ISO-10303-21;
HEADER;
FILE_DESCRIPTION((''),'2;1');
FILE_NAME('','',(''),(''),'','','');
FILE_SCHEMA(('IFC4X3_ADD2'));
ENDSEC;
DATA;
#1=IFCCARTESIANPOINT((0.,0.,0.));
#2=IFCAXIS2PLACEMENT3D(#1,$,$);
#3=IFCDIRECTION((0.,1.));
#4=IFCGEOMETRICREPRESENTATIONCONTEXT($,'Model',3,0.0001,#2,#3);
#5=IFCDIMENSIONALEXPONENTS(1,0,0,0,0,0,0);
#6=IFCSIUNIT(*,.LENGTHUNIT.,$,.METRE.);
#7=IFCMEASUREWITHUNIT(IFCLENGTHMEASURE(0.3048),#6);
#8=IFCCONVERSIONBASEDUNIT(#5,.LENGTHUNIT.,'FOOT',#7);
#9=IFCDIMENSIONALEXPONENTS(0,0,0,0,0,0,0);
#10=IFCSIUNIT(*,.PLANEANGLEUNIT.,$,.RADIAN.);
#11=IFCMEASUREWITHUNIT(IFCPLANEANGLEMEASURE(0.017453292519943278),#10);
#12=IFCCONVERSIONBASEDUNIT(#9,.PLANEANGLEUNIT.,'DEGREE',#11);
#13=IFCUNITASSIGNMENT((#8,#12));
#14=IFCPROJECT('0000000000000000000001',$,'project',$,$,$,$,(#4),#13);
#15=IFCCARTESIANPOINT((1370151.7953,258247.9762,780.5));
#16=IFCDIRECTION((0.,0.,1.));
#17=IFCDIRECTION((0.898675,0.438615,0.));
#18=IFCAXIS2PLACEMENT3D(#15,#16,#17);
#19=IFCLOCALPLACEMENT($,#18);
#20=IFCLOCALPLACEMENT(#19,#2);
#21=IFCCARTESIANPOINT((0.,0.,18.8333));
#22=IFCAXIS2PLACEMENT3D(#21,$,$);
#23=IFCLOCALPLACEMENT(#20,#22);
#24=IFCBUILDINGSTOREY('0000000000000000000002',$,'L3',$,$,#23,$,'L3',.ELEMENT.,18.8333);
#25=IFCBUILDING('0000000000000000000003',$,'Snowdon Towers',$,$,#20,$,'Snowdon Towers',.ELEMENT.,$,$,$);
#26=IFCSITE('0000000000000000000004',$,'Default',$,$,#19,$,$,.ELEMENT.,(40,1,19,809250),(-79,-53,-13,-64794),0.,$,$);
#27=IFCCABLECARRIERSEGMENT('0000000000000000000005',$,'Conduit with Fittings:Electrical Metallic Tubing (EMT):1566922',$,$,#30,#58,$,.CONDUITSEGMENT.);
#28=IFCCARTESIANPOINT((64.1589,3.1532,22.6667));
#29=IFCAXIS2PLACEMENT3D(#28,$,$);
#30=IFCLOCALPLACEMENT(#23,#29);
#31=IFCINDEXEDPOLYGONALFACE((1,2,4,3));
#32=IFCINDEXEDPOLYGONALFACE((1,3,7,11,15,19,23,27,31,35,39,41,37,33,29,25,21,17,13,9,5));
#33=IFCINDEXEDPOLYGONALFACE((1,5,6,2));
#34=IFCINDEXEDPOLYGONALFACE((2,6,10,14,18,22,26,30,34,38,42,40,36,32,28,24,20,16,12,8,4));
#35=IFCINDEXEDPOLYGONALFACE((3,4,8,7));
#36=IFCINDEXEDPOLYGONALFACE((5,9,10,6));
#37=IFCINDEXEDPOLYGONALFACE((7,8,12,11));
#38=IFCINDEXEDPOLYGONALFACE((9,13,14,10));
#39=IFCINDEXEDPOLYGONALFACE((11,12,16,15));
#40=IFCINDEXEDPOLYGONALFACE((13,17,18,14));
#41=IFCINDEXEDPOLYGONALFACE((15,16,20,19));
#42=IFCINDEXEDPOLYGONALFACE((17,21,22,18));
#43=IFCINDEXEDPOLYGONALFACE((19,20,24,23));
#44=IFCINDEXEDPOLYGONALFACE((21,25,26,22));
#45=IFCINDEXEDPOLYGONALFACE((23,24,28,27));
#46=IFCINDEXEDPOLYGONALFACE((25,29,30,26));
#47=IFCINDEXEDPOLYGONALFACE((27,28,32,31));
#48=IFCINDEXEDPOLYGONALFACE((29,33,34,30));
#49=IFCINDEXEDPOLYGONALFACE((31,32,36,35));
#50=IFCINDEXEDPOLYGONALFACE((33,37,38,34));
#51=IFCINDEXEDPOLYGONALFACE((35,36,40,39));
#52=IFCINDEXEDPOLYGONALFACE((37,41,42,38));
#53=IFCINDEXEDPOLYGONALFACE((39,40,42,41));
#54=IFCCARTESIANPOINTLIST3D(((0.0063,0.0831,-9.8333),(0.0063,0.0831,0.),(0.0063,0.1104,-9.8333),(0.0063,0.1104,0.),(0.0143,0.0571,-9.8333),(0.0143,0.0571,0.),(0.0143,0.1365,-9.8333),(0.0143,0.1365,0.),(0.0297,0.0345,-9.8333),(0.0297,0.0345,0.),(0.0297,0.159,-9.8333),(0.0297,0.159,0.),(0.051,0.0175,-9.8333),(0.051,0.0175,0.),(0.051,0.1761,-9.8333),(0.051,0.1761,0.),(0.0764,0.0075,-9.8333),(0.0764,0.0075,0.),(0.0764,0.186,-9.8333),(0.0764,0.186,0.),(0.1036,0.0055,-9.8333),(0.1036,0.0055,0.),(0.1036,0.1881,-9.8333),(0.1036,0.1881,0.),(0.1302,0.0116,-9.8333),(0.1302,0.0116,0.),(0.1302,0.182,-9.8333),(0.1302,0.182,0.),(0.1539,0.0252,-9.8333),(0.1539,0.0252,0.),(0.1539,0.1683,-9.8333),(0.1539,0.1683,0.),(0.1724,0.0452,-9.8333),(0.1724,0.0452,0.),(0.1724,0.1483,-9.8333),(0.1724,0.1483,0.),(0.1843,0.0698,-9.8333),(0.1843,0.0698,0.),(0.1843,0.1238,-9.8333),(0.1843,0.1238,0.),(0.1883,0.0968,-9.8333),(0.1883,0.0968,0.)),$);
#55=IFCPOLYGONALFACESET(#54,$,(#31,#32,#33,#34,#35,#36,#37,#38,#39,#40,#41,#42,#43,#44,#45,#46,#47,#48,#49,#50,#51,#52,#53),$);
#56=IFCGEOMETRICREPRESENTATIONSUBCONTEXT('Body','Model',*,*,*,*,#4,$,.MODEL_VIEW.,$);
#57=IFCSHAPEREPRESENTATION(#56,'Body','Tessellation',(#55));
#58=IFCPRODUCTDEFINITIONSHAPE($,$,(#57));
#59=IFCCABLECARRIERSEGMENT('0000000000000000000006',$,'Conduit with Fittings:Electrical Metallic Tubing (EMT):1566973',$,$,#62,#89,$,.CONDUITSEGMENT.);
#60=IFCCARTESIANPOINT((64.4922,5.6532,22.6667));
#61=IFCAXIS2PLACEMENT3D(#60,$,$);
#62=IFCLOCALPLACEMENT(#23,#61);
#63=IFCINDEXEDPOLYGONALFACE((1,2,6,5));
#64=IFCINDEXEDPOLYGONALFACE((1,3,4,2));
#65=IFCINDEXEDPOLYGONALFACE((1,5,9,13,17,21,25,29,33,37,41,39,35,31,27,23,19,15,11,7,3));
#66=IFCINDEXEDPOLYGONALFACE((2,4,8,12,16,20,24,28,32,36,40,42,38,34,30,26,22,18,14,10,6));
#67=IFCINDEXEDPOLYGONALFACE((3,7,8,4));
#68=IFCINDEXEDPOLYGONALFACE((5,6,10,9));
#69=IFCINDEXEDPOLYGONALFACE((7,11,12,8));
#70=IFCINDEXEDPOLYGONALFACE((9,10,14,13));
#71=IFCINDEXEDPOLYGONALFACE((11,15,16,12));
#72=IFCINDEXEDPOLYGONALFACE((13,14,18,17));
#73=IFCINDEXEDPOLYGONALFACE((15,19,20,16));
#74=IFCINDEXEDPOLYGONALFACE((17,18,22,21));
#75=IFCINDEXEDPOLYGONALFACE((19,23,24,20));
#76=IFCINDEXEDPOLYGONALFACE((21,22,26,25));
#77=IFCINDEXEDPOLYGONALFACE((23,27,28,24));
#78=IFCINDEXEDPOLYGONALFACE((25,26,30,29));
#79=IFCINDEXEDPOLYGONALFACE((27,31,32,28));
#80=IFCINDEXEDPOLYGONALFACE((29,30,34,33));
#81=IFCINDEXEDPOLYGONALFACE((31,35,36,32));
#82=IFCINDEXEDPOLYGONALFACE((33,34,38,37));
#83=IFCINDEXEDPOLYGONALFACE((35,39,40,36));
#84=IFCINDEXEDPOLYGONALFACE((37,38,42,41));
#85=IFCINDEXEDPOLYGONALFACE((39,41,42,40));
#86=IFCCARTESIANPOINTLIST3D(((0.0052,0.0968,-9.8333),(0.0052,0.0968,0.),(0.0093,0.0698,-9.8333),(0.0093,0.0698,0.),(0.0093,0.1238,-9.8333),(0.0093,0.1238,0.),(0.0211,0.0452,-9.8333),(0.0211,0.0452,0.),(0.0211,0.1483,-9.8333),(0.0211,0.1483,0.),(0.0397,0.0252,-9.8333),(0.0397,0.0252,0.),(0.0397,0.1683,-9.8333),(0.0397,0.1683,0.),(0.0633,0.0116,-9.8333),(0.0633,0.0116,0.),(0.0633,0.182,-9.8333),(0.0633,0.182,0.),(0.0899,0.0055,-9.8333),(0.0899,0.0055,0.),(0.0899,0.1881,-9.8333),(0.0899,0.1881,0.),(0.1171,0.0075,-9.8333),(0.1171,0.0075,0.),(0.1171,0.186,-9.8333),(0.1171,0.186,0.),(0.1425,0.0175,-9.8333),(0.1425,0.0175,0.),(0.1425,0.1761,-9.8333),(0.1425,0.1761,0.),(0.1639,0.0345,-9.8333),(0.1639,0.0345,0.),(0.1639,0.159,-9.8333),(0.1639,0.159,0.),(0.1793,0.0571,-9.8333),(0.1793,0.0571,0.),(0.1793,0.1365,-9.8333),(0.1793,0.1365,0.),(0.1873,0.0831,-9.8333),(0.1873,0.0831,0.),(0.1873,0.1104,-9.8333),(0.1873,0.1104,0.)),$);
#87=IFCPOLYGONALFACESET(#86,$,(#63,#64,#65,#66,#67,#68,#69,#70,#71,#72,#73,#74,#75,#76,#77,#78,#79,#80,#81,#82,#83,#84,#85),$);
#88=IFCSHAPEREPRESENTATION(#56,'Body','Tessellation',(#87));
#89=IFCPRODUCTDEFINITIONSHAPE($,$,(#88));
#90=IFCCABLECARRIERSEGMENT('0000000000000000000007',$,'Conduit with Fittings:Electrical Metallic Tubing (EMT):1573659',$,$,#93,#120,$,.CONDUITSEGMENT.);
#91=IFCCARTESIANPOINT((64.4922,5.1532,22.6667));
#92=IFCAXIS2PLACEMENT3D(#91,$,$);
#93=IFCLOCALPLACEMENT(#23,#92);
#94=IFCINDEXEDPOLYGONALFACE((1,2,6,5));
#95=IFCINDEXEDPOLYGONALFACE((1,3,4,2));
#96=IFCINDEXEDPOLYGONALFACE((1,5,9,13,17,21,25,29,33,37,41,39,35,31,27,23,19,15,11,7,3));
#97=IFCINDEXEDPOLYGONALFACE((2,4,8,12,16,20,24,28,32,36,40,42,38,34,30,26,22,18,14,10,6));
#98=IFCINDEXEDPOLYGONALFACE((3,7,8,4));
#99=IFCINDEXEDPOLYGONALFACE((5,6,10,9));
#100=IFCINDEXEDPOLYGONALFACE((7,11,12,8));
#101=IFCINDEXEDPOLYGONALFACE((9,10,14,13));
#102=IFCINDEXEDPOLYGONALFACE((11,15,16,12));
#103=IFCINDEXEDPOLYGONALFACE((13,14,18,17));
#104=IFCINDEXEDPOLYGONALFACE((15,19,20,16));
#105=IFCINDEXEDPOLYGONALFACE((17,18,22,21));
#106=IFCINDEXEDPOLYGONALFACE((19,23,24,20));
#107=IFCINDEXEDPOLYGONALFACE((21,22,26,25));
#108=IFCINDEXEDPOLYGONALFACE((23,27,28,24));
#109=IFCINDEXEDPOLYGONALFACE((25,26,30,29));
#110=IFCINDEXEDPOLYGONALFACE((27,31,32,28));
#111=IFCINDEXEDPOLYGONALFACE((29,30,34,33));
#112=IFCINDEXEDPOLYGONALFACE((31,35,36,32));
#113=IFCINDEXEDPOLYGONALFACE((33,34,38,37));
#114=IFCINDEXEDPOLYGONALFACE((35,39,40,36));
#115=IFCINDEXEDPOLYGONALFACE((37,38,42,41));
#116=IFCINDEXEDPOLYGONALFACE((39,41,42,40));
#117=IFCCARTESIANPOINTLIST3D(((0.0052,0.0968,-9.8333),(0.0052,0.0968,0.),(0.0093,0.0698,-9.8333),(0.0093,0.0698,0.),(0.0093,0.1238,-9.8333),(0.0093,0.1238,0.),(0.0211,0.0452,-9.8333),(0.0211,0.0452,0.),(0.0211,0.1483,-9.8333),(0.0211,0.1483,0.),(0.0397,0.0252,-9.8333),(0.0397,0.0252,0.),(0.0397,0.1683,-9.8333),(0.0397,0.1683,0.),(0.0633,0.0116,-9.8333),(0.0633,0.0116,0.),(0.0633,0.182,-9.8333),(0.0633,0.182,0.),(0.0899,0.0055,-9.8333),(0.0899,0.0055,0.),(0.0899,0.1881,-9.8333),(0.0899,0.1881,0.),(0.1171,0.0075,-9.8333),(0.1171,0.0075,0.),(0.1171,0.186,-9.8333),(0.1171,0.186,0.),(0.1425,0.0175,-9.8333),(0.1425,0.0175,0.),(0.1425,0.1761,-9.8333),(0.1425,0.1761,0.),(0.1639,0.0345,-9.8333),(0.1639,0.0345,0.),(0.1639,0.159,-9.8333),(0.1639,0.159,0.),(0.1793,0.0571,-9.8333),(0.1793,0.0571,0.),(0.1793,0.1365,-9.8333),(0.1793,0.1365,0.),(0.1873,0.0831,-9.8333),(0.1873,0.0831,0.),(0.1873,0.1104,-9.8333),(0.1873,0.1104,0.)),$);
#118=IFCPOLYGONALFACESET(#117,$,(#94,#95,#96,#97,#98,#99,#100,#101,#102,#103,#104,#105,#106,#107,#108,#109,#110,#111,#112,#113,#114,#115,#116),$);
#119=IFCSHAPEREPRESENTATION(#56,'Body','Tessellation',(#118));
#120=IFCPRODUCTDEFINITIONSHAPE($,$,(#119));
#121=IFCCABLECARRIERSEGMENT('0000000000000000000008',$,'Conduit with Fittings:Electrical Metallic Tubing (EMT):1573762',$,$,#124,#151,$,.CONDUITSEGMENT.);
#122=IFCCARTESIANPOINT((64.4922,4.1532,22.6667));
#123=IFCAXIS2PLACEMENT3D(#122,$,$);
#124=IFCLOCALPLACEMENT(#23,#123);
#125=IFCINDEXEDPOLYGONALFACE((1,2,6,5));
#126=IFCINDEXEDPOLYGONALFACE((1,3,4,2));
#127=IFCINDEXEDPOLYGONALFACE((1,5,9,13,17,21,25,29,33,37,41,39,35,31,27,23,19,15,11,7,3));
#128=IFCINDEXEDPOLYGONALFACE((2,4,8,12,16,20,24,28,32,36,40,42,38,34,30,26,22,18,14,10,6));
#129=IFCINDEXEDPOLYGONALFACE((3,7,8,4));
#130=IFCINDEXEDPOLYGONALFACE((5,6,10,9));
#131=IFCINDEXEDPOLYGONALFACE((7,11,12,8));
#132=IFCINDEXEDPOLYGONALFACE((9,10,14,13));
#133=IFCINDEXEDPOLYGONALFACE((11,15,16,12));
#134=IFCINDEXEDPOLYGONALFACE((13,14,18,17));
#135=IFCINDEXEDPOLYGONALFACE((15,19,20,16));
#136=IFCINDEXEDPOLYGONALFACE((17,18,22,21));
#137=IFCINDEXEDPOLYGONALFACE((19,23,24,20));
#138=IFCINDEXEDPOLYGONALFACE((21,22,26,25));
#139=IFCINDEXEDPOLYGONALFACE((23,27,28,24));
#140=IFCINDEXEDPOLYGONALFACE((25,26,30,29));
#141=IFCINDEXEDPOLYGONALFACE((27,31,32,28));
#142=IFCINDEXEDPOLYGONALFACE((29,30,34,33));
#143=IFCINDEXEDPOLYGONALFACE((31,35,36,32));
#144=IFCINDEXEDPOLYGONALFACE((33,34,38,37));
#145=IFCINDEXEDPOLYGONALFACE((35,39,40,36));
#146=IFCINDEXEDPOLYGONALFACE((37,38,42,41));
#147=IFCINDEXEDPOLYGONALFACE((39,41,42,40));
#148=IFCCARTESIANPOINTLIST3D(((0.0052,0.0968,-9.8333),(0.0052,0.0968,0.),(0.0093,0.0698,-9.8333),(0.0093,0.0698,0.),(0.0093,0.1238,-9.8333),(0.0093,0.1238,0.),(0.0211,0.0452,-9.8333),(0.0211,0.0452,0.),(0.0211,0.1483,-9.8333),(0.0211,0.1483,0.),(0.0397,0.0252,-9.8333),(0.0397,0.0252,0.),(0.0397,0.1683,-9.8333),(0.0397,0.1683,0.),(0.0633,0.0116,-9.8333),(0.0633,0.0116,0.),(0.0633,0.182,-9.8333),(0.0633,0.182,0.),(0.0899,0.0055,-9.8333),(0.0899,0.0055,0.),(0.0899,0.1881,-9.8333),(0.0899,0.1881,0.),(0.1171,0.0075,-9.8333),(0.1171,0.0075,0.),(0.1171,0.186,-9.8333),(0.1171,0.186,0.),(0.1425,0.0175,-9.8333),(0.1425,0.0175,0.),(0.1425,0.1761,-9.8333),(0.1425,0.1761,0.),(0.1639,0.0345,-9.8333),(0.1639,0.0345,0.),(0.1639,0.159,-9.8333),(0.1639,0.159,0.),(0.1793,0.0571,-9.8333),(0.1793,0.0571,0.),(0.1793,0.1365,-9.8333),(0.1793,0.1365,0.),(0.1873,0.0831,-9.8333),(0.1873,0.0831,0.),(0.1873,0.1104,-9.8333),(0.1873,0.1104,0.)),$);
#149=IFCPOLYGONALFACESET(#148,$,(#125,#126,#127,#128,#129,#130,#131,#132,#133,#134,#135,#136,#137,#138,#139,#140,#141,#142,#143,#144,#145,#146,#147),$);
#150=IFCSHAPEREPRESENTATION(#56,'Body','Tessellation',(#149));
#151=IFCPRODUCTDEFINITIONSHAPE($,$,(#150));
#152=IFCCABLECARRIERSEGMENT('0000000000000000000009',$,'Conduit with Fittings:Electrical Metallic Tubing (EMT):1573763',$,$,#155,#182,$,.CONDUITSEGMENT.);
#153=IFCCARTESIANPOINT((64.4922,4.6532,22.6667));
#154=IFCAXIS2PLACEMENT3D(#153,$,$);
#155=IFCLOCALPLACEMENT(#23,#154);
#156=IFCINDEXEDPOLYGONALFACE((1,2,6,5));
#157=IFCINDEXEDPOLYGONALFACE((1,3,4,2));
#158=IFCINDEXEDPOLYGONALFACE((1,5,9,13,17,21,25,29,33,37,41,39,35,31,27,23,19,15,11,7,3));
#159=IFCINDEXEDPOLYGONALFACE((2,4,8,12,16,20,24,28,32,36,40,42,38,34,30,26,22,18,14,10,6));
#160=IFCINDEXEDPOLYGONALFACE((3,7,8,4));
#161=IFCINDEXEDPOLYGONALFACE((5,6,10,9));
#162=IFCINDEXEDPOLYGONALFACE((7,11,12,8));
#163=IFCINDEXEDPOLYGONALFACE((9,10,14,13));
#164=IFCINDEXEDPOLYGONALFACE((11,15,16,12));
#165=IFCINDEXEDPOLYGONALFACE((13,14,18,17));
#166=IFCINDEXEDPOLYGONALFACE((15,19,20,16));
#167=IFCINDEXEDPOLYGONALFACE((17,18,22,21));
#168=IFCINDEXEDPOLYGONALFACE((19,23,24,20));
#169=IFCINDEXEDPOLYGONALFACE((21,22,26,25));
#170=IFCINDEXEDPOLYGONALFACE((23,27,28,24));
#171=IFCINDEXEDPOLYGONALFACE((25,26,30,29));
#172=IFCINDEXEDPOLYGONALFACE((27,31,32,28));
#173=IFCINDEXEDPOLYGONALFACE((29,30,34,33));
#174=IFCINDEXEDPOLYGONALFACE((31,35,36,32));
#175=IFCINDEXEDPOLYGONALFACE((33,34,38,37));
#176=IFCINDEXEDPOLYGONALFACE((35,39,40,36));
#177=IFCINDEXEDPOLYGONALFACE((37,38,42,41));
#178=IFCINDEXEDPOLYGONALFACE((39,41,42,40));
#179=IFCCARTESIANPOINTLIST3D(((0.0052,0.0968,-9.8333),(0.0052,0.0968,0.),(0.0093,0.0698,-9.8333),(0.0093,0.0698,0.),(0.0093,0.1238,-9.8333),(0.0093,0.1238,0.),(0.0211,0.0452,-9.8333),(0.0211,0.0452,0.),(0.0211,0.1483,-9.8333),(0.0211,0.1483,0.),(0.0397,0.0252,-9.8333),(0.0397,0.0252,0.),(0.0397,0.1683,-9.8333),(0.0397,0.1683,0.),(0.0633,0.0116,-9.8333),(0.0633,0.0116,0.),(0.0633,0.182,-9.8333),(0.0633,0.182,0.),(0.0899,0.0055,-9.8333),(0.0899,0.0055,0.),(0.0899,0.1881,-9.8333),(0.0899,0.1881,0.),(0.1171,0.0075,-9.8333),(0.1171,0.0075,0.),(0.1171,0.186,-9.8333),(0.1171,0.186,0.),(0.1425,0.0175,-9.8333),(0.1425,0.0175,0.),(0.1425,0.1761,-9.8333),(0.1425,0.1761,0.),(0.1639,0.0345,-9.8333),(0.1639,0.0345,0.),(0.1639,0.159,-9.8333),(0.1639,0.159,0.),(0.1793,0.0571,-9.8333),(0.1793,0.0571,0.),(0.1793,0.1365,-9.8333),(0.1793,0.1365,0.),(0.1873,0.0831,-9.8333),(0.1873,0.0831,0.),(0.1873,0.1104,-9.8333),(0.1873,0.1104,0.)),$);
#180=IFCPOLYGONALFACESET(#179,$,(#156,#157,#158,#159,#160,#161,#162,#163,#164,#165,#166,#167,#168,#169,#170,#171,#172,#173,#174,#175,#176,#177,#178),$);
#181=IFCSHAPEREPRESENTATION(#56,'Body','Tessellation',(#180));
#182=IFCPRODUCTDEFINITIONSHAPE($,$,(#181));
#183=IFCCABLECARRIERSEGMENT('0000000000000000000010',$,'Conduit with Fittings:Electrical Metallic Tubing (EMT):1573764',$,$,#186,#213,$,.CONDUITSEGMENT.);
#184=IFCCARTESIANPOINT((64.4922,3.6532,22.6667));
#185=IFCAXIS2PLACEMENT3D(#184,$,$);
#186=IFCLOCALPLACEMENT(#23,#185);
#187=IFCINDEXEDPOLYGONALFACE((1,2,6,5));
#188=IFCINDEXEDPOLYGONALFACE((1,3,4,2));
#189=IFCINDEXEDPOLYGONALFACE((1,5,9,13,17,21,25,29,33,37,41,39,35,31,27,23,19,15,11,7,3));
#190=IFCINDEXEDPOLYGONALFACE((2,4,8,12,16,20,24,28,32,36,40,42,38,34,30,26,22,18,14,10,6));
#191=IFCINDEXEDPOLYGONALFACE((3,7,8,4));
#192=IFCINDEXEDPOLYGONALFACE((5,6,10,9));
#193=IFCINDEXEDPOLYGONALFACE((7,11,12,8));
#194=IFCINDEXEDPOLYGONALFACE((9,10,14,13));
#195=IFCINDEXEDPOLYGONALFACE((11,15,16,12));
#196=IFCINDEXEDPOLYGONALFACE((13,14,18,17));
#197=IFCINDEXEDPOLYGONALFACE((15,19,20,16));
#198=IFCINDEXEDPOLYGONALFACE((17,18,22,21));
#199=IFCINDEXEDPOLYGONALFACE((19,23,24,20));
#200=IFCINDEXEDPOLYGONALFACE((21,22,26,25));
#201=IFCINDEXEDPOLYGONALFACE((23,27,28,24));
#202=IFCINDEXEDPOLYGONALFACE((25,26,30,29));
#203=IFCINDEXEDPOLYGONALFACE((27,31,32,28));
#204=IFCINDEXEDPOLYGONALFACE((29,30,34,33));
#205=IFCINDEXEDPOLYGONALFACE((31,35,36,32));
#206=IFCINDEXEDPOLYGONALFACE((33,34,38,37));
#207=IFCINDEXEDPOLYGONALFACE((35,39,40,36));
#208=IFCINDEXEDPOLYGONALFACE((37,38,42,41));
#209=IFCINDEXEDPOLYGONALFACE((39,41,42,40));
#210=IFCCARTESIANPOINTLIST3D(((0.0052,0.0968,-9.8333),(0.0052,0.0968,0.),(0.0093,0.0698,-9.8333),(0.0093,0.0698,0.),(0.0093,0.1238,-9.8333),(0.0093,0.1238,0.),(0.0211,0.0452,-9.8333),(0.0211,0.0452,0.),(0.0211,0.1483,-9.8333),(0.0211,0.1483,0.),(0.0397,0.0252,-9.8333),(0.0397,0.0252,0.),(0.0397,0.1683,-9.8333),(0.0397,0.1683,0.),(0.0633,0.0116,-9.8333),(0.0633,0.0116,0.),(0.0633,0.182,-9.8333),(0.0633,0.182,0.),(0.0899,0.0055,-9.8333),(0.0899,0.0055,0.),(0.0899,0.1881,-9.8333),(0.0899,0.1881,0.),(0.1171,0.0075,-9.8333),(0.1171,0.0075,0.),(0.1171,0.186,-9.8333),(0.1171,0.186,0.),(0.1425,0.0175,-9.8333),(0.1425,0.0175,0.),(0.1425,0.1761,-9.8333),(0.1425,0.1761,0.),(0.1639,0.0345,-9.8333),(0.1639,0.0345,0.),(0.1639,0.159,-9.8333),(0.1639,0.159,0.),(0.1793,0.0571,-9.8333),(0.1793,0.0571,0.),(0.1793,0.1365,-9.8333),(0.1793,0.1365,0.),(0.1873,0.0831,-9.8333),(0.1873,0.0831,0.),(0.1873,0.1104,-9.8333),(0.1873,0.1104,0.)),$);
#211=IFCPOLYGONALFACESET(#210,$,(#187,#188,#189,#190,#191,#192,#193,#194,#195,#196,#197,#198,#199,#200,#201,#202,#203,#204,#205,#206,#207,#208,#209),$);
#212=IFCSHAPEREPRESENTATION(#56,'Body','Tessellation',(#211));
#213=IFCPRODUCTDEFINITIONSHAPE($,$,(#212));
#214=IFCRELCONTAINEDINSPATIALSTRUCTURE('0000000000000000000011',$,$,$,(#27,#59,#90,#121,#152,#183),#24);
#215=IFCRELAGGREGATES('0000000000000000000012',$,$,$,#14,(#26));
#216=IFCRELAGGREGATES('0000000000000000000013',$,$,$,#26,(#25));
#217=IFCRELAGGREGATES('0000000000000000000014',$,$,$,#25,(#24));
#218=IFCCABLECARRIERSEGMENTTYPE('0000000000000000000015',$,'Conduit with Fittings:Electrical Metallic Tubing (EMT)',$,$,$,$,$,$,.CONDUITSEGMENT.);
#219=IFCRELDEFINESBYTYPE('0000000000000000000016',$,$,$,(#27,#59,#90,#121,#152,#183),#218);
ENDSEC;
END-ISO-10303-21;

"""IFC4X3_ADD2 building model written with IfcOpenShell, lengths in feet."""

from ifc_helpers import new_model, entity, si_unit, converted_unit, direction, frame, frame_2d, origin, origin_2d_with_axis, place, context, subcontext, project, spatial, circle, extrude, type_object, element, save


model = new_model("IFC4X3_ADD2")

# Units and contexts
model_context = context("Model", 3, precision=0.0001, world=origin(), true_north=direction((0.0, 1.0)))
body_context = subcontext(model_context, "Body", "Model", "MODEL_VIEW")
ifc_project = project(units=[converted_unit("LENGTHUNIT", "FOOT", entity("IfcLengthMeasure", 0.3048), si_unit("LENGTHUNIT", "METRE"), dimensions=[1, 0, 0, 0, 0, 0, 0]), converted_unit("PLANEANGLEUNIT", "DEGREE", entity("IfcPlaneAngleMeasure", 0.017453292519943278), si_unit("PLANEANGLEUNIT", "RADIAN"), dimensions=[0, 0, 0, 0, 0, 0, 0])], contexts=[model_context])

# Site, building, storey
site_placement = place(None, frame((1370151.7953, 258247.9762, 780.5), z_axis=(0.0, 0.0, 1.0), x_axis=(0.898675, 0.438615, 0.0)))
site = spatial("IfcSite", under=ifc_project, at=site_placement, Name="Default", CompositionType="ELEMENT", RefLatitude=(40, 1, 19, 809250), RefLongitude=(-79, -53, -13, -64794), RefElevation=0.0)
building_placement = place(site_placement, origin())
building = spatial("IfcBuilding", under=site, at=building_placement, Name="Snowdon Towers", LongName="Snowdon Towers", CompositionType="ELEMENT")
storey_placement = place(building_placement, frame((0.0, 0.0, 18.8333)))
storey = spatial("IfcBuildingStorey", under=building, at=storey_placement, Name="L3", LongName="L3", CompositionType="ELEMENT", Elevation=18.8333)

# Cable carrier segments
cable_carrier_segment_type = type_object("IfcCableCarrierSegmentType", Name="Conduit with Fittings:Electrical Metallic Tubing (EMT)", PredefinedType="CONDUITSEGMENT")
cable_carrier_segment_1_placement = place(storey_placement, frame((64.1589, 3.1532, 22.6667)))
element("IfcCableCarrierSegment", 1, at=cable_carrier_segment_1_placement, inside=storey, type_object=cable_carrier_segment_type, Name="Conduit with Fittings:Electrical Metallic Tubing (EMT):1566922", PredefinedType="CONDUITSEGMENT", context=body_context, shape_type="SweptSolid", body=[
    extrude(circle(Radius=0.0915, at=origin_2d_with_axis()), frame((0.0968, 0.0968, -9.8333)), (0.0, 0.0, 1.0), 9.8333),
])
for number, where, name in (
    (2, (64.4922, 5.6532, 22.6667), "Conduit with Fittings:Electrical Metallic Tubing (EMT):1566973"),
    (3, (64.4922, 5.1532, 22.6667), "Conduit with Fittings:Electrical Metallic Tubing (EMT):1573659"),
    (4, (64.4922, 4.1532, 22.6667), "Conduit with Fittings:Electrical Metallic Tubing (EMT):1573762"),
    (5, (64.4922, 4.6532, 22.6667), "Conduit with Fittings:Electrical Metallic Tubing (EMT):1573763"),
):
    element("IfcCableCarrierSegment", number, at=place(storey_placement, frame(where)), inside=storey, type_object=cable_carrier_segment_type, Name=name, PredefinedType="CONDUITSEGMENT", context=body_context, shape_type="SweptSolid", body=[
        extrude(circle(Radius=0.0915, at=frame_2d((0.0, 0.0), x_axis=(1.0, 0.0))), frame((0.0968, 0.0968, -9.8333), z_axis=(0.0, 0.0, 1.0), x_axis=(-1.0, 0.0, 0.0)), (0.0, 0.0, 1.0), 9.8333),
    ])
cable_carrier_segment_2_placement = place(storey_placement, frame((64.4922, 3.6532, 22.6667)))
element("IfcCableCarrierSegment", 6, at=cable_carrier_segment_2_placement, inside=storey, type_object=cable_carrier_segment_type, Name="Conduit with Fittings:Electrical Metallic Tubing (EMT):1573764", PredefinedType="CONDUITSEGMENT", context=body_context, shape_type="SweptSolid", body=[
    extrude(circle(Radius=0.0915, at=frame_2d((0.0, 0.0), x_axis=(1.0, 0.0))), frame((0.0968, 0.0968, -9.8333), z_axis=(0.0, 0.0, 1.0), x_axis=(-1.0, 0.0, 0.0)), (0.0, 0.0, 1.0), 9.8333),
])

save(model, "model.ifc")
